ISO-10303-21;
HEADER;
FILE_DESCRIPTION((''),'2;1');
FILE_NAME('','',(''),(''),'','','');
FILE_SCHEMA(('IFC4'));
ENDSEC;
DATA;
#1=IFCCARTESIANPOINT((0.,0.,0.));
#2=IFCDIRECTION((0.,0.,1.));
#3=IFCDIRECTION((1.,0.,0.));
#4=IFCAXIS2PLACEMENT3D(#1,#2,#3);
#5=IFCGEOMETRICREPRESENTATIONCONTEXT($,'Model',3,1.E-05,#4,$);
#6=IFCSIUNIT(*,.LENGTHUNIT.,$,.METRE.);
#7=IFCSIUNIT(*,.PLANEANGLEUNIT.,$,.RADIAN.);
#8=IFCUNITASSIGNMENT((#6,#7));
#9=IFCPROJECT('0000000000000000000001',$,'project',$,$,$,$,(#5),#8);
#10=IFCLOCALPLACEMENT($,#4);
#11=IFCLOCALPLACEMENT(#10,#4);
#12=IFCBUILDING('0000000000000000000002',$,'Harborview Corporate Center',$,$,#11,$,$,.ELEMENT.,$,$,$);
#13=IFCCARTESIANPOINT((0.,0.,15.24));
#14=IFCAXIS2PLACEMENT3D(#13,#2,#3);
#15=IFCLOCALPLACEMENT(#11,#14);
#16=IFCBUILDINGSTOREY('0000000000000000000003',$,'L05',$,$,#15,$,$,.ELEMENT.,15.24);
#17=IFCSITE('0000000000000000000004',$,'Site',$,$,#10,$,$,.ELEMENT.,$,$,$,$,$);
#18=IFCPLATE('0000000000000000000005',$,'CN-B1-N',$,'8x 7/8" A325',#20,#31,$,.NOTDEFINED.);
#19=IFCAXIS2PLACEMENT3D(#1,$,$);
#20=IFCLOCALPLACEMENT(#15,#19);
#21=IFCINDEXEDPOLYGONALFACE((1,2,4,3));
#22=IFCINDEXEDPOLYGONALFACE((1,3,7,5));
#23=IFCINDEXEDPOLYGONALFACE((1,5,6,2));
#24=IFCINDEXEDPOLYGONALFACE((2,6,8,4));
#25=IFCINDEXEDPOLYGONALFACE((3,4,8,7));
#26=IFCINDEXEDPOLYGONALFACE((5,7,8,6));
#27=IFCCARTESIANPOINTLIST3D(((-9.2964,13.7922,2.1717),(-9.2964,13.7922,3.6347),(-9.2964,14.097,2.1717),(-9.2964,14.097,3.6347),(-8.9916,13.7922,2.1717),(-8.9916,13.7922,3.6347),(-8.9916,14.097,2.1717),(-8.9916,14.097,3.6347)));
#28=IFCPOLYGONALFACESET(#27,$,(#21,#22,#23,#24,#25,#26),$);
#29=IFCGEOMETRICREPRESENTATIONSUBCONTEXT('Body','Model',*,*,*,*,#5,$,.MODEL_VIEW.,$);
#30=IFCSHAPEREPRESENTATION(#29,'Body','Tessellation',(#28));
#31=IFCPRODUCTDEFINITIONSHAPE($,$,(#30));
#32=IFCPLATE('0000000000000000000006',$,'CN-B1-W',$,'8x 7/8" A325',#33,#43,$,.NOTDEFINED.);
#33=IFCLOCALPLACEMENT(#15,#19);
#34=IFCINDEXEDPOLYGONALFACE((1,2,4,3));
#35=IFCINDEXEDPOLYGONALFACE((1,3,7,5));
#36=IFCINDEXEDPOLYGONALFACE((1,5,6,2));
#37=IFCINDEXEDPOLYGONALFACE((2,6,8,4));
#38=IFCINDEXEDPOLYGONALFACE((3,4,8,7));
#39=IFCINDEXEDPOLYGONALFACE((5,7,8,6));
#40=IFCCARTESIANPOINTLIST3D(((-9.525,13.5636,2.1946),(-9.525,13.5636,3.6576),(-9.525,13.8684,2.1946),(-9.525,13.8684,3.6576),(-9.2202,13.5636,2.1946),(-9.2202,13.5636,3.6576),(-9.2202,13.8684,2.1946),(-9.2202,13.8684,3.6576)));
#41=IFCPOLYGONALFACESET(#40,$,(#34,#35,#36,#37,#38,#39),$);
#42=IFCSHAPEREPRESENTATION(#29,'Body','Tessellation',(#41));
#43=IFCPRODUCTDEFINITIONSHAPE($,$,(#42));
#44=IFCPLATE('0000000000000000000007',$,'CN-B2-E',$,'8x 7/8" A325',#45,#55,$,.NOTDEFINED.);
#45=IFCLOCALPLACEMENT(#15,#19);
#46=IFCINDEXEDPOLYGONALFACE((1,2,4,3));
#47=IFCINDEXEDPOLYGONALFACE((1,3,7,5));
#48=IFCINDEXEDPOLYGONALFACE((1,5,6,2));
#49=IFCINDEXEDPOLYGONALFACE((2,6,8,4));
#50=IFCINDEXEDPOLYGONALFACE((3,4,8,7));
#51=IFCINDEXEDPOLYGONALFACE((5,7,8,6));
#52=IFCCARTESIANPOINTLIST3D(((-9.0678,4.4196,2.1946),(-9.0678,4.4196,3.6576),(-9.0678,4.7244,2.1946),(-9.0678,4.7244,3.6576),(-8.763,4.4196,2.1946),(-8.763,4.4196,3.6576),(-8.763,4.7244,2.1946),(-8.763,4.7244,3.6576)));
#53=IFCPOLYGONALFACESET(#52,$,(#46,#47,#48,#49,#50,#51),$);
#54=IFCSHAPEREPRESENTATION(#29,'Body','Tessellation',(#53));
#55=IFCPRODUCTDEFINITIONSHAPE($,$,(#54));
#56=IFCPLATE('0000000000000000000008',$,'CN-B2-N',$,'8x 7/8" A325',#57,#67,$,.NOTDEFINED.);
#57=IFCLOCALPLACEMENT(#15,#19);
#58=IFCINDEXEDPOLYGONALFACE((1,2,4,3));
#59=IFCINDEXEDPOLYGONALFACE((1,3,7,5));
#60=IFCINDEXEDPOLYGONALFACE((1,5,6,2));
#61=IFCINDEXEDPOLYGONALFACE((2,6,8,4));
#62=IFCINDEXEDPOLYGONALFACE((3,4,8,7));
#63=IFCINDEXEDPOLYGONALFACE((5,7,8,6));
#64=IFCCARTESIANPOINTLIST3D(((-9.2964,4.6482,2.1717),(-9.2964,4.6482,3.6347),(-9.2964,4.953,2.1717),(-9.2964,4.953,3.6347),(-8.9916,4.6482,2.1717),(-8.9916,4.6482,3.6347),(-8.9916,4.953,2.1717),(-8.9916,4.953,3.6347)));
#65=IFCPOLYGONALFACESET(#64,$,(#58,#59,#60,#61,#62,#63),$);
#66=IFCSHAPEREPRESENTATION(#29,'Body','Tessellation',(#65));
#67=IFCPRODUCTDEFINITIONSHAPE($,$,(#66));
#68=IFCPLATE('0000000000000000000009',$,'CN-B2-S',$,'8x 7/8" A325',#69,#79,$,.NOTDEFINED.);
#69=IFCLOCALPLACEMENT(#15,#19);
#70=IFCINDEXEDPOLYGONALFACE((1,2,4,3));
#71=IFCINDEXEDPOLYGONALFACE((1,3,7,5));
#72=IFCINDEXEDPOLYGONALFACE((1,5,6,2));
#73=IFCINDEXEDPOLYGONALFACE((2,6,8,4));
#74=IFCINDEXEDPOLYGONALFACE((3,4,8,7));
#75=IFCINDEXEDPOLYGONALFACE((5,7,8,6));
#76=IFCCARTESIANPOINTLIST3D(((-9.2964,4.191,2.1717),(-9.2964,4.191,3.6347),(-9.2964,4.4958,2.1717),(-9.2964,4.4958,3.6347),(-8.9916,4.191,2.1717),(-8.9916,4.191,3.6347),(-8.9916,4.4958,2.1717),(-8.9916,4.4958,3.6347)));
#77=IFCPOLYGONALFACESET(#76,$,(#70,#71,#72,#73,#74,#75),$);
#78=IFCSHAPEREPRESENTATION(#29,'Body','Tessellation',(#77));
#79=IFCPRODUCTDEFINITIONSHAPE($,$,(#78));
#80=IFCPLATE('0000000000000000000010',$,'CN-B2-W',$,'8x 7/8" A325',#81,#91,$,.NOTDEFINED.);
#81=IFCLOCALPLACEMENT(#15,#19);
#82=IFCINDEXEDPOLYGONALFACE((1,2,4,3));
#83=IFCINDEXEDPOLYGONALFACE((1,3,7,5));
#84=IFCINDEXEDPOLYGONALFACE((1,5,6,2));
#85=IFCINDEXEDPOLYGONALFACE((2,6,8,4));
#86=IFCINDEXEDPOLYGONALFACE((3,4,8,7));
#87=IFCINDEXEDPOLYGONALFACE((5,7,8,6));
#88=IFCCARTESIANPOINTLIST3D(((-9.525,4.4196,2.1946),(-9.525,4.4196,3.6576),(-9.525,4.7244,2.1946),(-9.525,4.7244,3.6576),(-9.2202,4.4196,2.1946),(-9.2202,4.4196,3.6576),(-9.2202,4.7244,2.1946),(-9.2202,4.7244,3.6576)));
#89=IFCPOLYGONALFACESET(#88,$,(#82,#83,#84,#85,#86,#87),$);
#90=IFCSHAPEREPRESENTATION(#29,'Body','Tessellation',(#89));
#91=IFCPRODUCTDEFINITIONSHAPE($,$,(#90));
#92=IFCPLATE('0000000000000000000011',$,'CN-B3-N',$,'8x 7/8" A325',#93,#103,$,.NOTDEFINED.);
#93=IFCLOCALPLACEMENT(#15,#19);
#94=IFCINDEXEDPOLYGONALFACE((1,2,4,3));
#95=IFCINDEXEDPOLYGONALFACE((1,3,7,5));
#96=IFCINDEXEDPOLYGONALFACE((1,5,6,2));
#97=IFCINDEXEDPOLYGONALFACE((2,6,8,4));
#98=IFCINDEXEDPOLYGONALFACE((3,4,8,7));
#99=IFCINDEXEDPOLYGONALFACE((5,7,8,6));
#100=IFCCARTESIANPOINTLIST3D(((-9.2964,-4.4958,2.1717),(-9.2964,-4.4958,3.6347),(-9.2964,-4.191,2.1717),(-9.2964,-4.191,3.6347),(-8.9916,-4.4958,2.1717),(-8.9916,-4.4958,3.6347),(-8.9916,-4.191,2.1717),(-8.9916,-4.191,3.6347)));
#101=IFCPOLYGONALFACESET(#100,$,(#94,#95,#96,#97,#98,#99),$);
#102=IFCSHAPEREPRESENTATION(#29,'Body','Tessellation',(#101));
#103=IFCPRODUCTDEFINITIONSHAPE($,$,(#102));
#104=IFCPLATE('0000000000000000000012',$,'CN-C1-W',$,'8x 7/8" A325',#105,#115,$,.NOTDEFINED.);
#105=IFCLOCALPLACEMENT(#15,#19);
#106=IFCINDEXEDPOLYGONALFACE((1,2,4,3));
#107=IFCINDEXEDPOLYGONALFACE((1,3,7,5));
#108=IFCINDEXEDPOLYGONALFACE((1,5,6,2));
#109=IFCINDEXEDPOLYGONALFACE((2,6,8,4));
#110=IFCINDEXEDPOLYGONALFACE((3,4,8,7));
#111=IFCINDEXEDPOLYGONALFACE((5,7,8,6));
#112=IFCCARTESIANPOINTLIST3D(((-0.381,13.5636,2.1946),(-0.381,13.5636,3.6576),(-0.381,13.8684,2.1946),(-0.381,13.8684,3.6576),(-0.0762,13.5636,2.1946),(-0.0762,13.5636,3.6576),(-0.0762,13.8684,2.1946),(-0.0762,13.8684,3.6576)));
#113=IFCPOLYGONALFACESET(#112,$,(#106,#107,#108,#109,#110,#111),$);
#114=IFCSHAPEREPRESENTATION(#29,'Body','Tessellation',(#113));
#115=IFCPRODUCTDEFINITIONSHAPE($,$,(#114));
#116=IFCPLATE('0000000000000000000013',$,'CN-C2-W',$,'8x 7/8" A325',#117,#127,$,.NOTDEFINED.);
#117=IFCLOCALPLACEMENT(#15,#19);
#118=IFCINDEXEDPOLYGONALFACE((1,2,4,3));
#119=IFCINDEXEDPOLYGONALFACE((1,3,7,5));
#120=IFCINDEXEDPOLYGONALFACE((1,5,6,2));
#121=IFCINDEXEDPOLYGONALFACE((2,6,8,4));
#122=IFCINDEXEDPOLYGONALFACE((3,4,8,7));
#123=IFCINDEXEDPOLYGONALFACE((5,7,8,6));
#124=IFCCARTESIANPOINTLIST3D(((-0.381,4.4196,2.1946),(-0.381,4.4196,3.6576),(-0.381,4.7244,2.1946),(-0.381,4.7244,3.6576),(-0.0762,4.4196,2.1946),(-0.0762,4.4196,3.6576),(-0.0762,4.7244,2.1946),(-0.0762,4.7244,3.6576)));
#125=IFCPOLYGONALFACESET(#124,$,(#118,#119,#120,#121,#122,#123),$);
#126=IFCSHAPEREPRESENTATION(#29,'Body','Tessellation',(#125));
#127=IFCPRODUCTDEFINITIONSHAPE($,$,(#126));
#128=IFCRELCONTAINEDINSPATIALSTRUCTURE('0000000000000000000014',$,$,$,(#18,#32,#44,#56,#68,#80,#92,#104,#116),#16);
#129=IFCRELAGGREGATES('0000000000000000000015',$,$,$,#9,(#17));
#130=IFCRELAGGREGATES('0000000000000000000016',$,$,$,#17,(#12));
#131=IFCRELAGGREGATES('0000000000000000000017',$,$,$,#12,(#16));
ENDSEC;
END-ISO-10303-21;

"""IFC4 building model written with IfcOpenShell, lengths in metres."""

from ifc_helpers import new_model, si_unit, frame, origin_with_axes, place, context, subcontext, project, spatial, rectangle, extrude, element, save


model = new_model("IFC4")

# Units and contexts
model_context = context("Model", 3, precision=1e-05, world=origin_with_axes())
body_context = subcontext(model_context, "Body", "Model", "MODEL_VIEW")
ifc_project = project(units=[si_unit("LENGTHUNIT", "METRE"), si_unit("PLANEANGLEUNIT", "RADIAN")], contexts=[model_context])

# Site, building, storey
site_placement = place(None, origin_with_axes())
site = spatial("IfcSite", under=ifc_project, at=site_placement, Name="Site", CompositionType="ELEMENT")
building_placement = place(site_placement, origin_with_axes())
building = spatial("IfcBuilding", under=site, at=building_placement, Name="Harborview Corporate Center", CompositionType="ELEMENT")
storey_placement = place(building_placement, frame((0.0, 0.0, 15.24), z_axis=(0.0, 0.0, 1.0), x_axis=(1.0, 0.0, 0.0)))
storey = spatial("IfcBuildingStorey", under=building, at=storey_placement, Name="L05", CompositionType="ELEMENT", Elevation=15.24)

# Plates
for number, where, z_axis, x_axis, name in (
    (1, (-9.144, 13.9446, 2.1717), (0.0, 0.0, 1.0), (1.0, 0.0, 0.0), "CN-B1-N"),
    (2, (-9.3726, 13.716, 2.1946), (0.0, 0.0, 1.0), (1.0, 0.0, 0.0), "CN-B1-W"),
    (3, (-8.9154, 4.572, 2.1946), (0.0, 0.0, 1.0), (1.0, 0.0, 0.0), "CN-B2-E"),
    (4, (-9.144, 4.8006, 2.1717), (0.0, 0.0, 1.0), (1.0, 0.0, 0.0), "CN-B2-N"),
    (5, (-9.144, 4.3434, 2.1717), (0.0, 0.0, 1.0), (1.0, 0.0, 0.0), "CN-B2-S"),
    (6, (-9.3726, 4.572, 2.1946), (0.0, 0.0, 1.0), (1.0, 0.0, 0.0), "CN-B2-W"),
    (7, (-9.144, -4.3434, 2.1717), (0.0, 0.0, 1.0), (1.0, 0.0, 0.0), "CN-B3-N"),
):
    element("IfcPlate", number, at=place(storey_placement, frame(where, z_axis=z_axis, x_axis=x_axis)), inside=storey, Name=name, ObjectType="8x 7/8\" A325", PredefinedType="NOTDEFINED", context=body_context, shape_type="SweptSolid", body=[
        extrude(rectangle(XDim=0.3048, YDim=0.3048), origin_with_axes(), (0.0, 0.0, 1.0), 1.463),
    ])
for number, where, z_axis, x_axis, name in (
    (8, (-0.2286, 13.716, 2.1946), (0.0, 0.0, 1.0), (1.0, 0.0, 0.0), "CN-C1-W"),
    (9, (-0.2286, 4.572, 2.1946), (0.0, 0.0, 1.0), (1.0, 0.0, 0.0), "CN-C2-W"),
):
    element("IfcPlate", number, at=place(storey_placement, frame(where, z_axis=z_axis, x_axis=x_axis)), inside=storey, Name=name, ObjectType="8x 7/8\" A325", PredefinedType="NOTDEFINED", context=body_context, shape_type="SweptSolid", body=[
        extrude(rectangle(XDim=0.3048, YDim=0.3048), origin_with_axes(), (0.0, 0.0, 1.0), 1.463),
    ])

save(model, "model.ifc")
